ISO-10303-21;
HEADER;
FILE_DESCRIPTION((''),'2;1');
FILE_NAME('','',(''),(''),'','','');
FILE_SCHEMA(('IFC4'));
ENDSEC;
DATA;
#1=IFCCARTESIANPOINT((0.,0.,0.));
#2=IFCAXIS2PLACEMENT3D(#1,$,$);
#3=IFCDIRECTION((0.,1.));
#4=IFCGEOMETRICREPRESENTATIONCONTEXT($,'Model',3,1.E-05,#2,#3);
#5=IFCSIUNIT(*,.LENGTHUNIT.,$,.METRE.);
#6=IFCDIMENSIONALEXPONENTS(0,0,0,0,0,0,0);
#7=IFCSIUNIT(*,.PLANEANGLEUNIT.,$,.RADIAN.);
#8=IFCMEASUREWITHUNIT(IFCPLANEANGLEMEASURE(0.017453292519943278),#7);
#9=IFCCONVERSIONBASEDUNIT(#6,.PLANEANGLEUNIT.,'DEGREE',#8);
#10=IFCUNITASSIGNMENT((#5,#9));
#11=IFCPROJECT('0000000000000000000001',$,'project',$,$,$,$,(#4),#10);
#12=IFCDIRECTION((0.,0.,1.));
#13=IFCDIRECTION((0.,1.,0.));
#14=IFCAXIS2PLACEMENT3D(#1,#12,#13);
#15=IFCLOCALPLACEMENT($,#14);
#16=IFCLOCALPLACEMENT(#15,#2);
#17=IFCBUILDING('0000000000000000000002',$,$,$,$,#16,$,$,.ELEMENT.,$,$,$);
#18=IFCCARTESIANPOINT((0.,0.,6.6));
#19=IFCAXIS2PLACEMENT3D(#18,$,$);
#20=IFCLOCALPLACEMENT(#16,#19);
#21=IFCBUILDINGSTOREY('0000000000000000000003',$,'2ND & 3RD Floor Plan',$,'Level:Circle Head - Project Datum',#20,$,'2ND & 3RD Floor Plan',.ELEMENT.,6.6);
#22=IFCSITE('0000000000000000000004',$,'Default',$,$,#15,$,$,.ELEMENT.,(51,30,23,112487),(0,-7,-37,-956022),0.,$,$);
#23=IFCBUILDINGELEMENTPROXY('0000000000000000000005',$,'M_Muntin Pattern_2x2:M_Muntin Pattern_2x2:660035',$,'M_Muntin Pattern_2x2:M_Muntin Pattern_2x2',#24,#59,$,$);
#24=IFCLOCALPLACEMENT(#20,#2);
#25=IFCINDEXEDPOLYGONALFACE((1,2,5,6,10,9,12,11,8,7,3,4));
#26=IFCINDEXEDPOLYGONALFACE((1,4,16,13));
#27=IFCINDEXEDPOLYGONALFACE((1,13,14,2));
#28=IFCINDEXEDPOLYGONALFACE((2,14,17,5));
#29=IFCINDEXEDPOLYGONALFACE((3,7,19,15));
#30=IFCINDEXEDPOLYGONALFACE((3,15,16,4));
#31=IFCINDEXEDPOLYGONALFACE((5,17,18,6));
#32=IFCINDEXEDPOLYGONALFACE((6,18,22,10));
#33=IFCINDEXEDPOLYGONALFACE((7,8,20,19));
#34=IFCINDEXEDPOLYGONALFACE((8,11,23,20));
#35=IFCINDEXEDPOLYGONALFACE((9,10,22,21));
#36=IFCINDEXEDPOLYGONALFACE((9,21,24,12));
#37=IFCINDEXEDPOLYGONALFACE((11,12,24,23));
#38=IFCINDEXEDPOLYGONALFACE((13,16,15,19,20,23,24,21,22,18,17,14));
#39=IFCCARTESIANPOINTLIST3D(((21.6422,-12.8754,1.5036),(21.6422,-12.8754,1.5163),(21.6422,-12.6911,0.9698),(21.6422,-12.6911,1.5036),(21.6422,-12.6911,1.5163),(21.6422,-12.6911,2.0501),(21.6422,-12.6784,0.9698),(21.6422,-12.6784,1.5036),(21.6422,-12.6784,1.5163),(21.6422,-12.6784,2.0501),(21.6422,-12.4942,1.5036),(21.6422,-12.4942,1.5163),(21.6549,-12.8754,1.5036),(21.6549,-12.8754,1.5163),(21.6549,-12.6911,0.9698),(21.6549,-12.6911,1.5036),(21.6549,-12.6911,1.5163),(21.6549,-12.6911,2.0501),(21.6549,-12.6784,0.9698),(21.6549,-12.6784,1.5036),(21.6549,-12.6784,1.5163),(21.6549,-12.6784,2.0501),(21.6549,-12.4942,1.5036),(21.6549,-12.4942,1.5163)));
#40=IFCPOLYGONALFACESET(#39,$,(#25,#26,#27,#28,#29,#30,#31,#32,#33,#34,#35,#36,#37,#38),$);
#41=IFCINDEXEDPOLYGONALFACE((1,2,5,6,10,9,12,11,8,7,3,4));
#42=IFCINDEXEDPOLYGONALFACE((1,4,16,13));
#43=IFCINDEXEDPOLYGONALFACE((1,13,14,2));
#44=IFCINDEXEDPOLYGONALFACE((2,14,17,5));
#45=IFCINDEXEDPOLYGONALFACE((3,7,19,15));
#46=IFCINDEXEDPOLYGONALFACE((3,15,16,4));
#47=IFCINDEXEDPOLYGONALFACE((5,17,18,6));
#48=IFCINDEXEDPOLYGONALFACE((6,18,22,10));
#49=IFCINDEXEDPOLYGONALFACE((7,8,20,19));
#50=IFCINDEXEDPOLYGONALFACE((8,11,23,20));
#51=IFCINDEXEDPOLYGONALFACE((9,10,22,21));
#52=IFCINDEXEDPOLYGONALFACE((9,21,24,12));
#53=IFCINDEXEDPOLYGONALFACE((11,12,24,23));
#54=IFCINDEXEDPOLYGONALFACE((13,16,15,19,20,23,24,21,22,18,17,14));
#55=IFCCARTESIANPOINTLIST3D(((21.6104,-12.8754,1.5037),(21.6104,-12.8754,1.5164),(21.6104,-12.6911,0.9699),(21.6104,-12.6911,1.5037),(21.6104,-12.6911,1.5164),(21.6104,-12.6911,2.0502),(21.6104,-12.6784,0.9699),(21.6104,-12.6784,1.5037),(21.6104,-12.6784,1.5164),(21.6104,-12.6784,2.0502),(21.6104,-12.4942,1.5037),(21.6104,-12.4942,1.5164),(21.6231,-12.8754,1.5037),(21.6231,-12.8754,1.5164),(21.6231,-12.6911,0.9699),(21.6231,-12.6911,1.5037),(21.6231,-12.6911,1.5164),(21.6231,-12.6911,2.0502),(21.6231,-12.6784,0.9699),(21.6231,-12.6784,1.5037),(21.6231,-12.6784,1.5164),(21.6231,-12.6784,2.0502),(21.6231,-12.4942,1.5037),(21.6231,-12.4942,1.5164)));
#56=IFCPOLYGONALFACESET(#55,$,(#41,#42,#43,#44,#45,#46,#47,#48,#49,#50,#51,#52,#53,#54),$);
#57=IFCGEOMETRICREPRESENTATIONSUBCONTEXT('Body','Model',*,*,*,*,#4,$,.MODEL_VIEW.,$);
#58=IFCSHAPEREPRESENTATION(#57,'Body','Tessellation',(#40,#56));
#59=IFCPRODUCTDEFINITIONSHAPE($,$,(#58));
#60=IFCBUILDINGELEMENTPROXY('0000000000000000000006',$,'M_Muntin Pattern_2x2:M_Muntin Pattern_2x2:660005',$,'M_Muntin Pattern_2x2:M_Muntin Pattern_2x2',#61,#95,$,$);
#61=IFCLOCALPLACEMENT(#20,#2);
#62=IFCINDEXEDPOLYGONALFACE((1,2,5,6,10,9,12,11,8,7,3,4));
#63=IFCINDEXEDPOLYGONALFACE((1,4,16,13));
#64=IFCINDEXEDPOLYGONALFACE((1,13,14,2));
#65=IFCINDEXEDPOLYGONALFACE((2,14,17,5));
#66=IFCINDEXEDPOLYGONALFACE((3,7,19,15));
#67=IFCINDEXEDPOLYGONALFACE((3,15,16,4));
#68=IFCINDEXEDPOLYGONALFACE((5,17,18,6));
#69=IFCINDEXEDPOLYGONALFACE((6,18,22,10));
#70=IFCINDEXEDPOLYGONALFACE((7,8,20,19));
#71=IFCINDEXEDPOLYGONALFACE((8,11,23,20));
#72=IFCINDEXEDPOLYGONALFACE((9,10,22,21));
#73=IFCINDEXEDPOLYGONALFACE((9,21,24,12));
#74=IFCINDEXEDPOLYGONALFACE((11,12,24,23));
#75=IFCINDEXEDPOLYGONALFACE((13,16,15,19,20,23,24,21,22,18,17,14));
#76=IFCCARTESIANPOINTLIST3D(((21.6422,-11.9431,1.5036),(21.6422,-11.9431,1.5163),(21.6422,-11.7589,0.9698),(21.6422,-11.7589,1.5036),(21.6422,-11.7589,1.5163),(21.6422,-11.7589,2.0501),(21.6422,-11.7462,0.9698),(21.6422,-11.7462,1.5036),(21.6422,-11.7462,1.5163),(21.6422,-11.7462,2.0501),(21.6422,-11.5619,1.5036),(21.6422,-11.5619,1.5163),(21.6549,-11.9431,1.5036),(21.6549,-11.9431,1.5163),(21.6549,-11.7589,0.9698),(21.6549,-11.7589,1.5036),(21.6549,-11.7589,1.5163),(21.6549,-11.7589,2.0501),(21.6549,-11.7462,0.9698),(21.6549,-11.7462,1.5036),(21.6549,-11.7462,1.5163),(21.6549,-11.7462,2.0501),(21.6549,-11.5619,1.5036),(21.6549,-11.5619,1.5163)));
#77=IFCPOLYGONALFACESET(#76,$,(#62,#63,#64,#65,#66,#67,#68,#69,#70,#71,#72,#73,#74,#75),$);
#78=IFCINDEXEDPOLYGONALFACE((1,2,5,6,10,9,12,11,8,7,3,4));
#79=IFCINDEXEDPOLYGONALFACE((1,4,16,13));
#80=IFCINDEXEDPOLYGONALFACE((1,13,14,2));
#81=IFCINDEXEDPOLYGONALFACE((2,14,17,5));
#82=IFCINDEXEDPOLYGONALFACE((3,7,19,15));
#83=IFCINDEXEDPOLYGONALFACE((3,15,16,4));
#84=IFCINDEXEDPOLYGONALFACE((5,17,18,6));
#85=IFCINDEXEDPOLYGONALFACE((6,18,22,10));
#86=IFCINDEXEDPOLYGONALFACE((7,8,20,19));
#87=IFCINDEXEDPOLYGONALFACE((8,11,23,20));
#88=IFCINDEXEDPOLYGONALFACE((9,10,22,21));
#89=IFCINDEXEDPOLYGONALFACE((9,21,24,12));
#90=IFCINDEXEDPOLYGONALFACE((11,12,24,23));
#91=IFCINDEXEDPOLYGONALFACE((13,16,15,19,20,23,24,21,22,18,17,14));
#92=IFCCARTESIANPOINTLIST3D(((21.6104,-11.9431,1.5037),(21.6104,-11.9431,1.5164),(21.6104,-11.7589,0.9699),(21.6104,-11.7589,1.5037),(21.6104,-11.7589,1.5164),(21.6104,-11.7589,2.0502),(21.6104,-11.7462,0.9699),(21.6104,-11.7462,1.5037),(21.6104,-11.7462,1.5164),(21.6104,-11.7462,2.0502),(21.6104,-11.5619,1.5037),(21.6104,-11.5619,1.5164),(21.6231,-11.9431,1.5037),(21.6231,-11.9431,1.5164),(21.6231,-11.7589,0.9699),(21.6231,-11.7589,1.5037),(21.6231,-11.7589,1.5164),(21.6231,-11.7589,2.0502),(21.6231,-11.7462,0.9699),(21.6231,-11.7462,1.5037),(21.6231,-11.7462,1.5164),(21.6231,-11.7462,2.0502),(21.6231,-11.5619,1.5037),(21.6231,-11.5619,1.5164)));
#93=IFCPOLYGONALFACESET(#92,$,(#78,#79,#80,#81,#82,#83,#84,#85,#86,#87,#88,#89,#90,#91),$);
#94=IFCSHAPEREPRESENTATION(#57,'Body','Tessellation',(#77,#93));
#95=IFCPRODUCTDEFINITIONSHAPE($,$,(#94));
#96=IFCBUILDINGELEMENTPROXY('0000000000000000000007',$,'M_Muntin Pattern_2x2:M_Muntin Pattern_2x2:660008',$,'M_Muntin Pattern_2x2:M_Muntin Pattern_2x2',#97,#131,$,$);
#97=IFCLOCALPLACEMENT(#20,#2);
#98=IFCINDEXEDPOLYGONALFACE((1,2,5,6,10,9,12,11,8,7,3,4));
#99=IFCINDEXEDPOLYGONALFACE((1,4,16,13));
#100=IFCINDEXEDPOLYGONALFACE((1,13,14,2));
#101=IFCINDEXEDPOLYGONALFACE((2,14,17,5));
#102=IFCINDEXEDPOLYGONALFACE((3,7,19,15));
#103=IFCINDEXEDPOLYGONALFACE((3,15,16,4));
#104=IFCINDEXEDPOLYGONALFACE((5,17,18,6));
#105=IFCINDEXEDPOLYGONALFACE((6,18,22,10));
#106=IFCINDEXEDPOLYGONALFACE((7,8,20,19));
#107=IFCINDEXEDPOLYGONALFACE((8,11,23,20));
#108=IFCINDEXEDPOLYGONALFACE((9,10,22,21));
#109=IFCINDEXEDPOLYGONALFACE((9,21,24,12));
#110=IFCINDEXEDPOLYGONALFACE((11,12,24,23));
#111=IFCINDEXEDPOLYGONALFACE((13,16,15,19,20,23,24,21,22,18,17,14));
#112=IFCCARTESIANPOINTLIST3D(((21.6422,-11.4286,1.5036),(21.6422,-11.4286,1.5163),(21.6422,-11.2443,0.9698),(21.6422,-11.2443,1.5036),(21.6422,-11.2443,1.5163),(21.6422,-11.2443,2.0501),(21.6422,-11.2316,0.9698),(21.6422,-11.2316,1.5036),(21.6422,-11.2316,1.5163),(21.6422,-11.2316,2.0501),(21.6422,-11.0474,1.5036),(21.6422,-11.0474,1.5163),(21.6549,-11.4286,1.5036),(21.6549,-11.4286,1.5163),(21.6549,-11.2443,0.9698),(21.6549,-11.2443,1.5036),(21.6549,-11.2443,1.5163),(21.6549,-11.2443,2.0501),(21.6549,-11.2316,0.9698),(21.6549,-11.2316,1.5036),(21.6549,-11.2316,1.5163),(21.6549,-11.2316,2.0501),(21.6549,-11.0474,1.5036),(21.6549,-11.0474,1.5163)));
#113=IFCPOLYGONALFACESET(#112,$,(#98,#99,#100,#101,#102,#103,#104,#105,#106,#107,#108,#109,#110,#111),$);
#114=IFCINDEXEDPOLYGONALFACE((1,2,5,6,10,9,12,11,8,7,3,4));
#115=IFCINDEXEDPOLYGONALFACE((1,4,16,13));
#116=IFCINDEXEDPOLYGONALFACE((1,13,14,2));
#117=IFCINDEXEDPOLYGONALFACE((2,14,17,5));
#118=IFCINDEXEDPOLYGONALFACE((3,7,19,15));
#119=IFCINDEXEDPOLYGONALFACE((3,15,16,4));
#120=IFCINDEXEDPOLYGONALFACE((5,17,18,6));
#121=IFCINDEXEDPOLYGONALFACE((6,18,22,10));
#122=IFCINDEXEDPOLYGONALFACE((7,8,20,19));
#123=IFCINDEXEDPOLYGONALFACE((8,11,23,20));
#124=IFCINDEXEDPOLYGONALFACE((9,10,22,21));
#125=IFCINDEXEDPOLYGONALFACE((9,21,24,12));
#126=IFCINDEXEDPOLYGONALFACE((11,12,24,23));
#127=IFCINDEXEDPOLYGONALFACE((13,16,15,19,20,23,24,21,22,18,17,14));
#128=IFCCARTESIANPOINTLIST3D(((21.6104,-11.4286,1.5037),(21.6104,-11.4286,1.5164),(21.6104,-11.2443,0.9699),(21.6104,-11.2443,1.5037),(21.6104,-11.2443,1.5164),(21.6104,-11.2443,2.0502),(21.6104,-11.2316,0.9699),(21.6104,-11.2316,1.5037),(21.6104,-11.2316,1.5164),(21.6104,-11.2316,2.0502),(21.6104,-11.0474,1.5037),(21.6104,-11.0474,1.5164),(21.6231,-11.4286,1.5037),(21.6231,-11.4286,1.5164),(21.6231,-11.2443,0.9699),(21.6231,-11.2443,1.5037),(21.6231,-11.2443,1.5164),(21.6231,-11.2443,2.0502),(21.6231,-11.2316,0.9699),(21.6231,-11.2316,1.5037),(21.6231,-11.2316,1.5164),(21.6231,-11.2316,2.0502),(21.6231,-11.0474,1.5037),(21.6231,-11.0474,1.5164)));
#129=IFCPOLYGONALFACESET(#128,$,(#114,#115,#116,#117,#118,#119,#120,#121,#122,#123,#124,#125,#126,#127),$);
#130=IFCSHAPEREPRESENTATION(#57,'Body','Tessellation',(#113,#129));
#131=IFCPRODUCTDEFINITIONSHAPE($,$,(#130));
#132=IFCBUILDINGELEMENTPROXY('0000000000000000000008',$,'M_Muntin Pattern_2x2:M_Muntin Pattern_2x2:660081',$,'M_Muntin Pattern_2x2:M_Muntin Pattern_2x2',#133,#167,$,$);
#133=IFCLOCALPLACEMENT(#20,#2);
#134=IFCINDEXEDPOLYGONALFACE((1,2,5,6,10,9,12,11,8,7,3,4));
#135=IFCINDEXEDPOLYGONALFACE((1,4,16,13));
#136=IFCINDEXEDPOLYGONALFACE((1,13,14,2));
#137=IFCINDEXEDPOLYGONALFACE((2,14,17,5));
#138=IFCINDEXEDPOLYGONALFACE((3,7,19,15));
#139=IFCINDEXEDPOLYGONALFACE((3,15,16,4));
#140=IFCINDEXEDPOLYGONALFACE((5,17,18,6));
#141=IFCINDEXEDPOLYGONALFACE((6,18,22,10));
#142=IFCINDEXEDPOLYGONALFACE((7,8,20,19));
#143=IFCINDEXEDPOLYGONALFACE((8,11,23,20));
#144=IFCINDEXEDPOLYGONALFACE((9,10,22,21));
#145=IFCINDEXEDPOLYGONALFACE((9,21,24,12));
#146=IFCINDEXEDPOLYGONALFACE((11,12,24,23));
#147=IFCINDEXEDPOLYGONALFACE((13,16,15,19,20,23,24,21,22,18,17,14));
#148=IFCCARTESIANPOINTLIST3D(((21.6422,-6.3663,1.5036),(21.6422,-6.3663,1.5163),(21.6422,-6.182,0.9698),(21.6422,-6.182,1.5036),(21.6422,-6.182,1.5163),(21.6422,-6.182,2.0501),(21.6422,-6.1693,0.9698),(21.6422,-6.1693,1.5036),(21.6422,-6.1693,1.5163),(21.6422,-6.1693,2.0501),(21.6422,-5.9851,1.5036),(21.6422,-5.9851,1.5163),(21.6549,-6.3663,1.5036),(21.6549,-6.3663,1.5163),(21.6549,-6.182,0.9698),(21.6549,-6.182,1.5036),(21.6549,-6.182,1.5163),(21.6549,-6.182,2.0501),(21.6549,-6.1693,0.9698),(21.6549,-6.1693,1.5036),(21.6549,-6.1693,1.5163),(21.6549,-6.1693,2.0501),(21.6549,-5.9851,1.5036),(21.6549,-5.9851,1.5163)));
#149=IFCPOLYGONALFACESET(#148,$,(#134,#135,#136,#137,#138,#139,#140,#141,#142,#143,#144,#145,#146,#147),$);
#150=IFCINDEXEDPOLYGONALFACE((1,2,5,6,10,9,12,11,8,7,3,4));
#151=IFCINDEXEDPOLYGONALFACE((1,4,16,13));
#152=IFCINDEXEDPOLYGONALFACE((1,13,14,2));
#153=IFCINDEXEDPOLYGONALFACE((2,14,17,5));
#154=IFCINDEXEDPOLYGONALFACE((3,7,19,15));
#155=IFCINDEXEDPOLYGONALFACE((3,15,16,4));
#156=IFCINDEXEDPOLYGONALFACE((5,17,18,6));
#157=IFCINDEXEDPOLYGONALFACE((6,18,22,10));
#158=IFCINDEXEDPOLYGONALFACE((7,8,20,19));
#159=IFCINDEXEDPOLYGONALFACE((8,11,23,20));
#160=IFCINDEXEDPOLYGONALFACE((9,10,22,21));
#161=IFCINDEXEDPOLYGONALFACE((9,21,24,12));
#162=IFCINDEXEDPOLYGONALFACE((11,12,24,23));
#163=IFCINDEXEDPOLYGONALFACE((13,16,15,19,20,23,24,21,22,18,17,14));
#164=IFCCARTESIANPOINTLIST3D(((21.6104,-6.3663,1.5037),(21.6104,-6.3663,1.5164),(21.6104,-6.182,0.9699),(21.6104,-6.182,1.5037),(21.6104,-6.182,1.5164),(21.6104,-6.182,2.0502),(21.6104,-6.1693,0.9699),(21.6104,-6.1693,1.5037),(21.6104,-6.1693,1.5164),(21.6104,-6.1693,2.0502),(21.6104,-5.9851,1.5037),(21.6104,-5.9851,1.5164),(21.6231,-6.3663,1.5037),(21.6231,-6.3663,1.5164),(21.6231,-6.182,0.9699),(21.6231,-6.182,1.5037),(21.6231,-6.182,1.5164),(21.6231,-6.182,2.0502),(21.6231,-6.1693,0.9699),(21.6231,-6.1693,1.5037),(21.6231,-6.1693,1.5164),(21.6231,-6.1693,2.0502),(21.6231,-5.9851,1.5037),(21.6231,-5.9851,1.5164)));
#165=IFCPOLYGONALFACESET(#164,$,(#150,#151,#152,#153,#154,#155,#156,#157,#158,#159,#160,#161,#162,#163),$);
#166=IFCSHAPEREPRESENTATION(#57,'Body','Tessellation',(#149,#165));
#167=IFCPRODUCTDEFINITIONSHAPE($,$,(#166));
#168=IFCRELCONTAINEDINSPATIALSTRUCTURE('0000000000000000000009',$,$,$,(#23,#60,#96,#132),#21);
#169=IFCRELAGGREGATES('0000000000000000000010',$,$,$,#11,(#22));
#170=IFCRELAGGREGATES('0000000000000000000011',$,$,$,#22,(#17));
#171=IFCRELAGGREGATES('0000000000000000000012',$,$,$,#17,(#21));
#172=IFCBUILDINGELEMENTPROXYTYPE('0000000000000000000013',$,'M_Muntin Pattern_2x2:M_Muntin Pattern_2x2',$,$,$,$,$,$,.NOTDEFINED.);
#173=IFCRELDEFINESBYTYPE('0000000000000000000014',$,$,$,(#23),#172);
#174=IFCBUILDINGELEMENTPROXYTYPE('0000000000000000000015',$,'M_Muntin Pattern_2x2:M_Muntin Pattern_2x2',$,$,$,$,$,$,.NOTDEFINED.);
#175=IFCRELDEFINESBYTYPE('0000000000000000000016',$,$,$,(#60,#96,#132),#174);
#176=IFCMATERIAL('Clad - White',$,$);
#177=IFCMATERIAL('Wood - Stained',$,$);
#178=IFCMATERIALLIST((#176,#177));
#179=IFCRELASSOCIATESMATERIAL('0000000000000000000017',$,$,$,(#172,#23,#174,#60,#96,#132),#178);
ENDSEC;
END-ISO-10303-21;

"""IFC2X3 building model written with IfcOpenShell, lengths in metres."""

from ifc_helpers import new_model, entity, si_unit, converted_unit, direction, frame, origin, place, context, subcontext, project, spatial, polyline, outline, extrude, source, transform, mapped, material, material_list, type_object, type_shapes, element, save


model = new_model("IFC2X3")

# Units and contexts
model_context = context("Model", 3, precision=1e-05, world=origin(), true_north=direction((0.0, 1.0)))
body_context = subcontext(model_context, "Body", "Model", "MODEL_VIEW")
ifc_project = project(units=[si_unit("LENGTHUNIT", "METRE"), converted_unit("PLANEANGLEUNIT", "DEGREE", entity("IfcPlaneAngleMeasure", 0.017453292519943278), si_unit("PLANEANGLEUNIT", "RADIAN"), dimensions=[0, 0, 0, 0, 0, 0, 0])], contexts=[model_context])

# Site, building, storey
site_placement = place(None, frame((0.0, 0.0, 0.0), z_axis=(0.0, 0.0, 1.0), x_axis=(0.0, 1.0, 0.0)))
site = spatial("IfcSite", under=ifc_project, at=site_placement, Name="Default", CompositionType="ELEMENT", RefLatitude=(51, 30, 23, 112487), RefLongitude=(0, -7, -37, -956022), RefElevation=0.0)
building_placement = place(site_placement, origin())
building = spatial("IfcBuilding", under=site, at=building_placement, CompositionType="ELEMENT")
storey_placement = place(building_placement, frame((0.0, 0.0, 6.6)))
storey = spatial("IfcBuildingStorey", under=building, at=storey_placement, Name="2ND & 3RD Floor Plan", ObjectType="Level:Circle Head - Project Datum", LongName="2ND & 3RD Floor Plan", CompositionType="ELEMENT", Elevation=6.6)

# Building element proxies
ifc_material_1 = material(Name="Clad - White")
ifc_material_2 = material(Name="Wood - Stained")
ifc_material_list = material_list([ifc_material_1, ifc_material_2])
building_element_proxy_type_1 = type_object("IfcBuildingElementProxyType", Name="M_Muntin Pattern_2x2:M_Muntin Pattern_2x2", PredefinedType="NOTDEFINED", material=ifc_material_list)
shared_shape_1 = source(origin(), body_context, "Body", "SweptSolid", [
    extrude(outline(polyline([(0.0064, -0.0064), (0.5401, -0.0064), (0.5401, 0.0063), (0.0064, 0.0063), (0.0064, 0.1906), (-0.0063, 0.1906), (-0.0063, 0.0063), (-0.5402, 0.0063), (-0.5402, -0.0064), (-0.0063, -0.0064), (-0.0063, -0.1906), (0.0064, -0.1906), (0.0064, -0.0064)])), frame((0.0, 0.0095, 0.5401), z_axis=(0.0, 1.0, 0.0), x_axis=(0.0, 0.0, 1.0)), (0.0, 0.0, 1.0), 0.0127),
    extrude(outline(polyline([(0.0064, -0.0064), (0.5402, -0.0064), (0.5402, 0.0063), (0.0064, 0.0063), (0.0064, 0.1906), (-0.0063, 0.1906), (-0.0063, 0.0063), (-0.5402, 0.0063), (-0.5402, -0.0064), (-0.0063, -0.0064), (-0.0063, -0.1906), (0.0064, -0.1906), (0.0064, -0.0064)])), frame((0.0, -0.0222, 0.5402), z_axis=(0.0, 1.0, 0.0), x_axis=(0.0, 0.0, 1.0)), (0.0, 0.0, 1.0), 0.0127),
])
type_shapes(building_element_proxy_type_1, [shared_shape_1])
for number, where, z_axis, x_axis, name in (
    (1, (21.6326, -12.6848, 0.9699), (0.0, 0.0, 1.0), (0.0, -1.0, 0.0), "M_Muntin Pattern_2x2:M_Muntin Pattern_2x2:660035"),
):
    element("IfcBuildingElementProxy", number, at=place(storey_placement, frame(where, z_axis=z_axis, x_axis=x_axis)), inside=storey, type_object=building_element_proxy_type_1, material=ifc_material_list, Name=name, ObjectType="M_Muntin Pattern_2x2:M_Muntin Pattern_2x2", context=body_context, shape_type="MappedRepresentation", body=[
        mapped(shared_shape_1, transform((0.0, 0.0, 0.0), scale=1.0)),
    ])
building_element_proxy_type_2 = type_object("IfcBuildingElementProxyType", Name="M_Muntin Pattern_2x2:M_Muntin Pattern_2x2", PredefinedType="NOTDEFINED", material=ifc_material_list)
shared_shape_2 = source(origin(), body_context, "Body", "SweptSolid", [
    extrude(outline(polyline([(0.0064, -0.0064), (0.5401, -0.0064), (0.5401, 0.0063), (0.0064, 0.0063), (0.0064, 0.1906), (-0.0063, 0.1906), (-0.0063, 0.0063), (-0.5402, 0.0063), (-0.5402, -0.0064), (-0.0063, -0.0064), (-0.0063, -0.1906), (0.0064, -0.1906), (0.0064, -0.0064)])), frame((0.0, -0.0222, 0.5401), z_axis=(0.0, 1.0, 0.0), x_axis=(0.0, 0.0, 1.0)), (0.0, 0.0, 1.0), 0.0127),
    extrude(outline(polyline([(0.0064, -0.0064), (0.5402, -0.0064), (0.5402, 0.0063), (0.0064, 0.0063), (0.0064, 0.1906), (-0.0063, 0.1906), (-0.0063, 0.0063), (-0.5402, 0.0063), (-0.5402, -0.0064), (-0.0063, -0.0064), (-0.0063, -0.1906), (0.0064, -0.1906), (0.0064, -0.0064)])), frame((0.0, 0.0095, 0.5402), z_axis=(0.0, 1.0, 0.0), x_axis=(0.0, 0.0, 1.0)), (0.0, 0.0, 1.0), 0.0127),
])
type_shapes(building_element_proxy_type_2, [shared_shape_2])
for number, where, z_axis, x_axis, name in (
    (2, (21.6326, -11.7525, 0.9699), (0.0, 0.0, 1.0), (0.0, 1.0, 0.0), "M_Muntin Pattern_2x2:M_Muntin Pattern_2x2:660005"),
    (3, (21.6326, -11.238, 0.9699), (0.0, 0.0, 1.0), (0.0, 1.0, 0.0), "M_Muntin Pattern_2x2:M_Muntin Pattern_2x2:660008"),
    (4, (21.6326, -6.1757, 0.9699), (0.0, 0.0, 1.0), (0.0, 1.0, 0.0), "M_Muntin Pattern_2x2:M_Muntin Pattern_2x2:660081"),
):
    element("IfcBuildingElementProxy", number, at=place(storey_placement, frame(where, z_axis=z_axis, x_axis=x_axis)), inside=storey, type_object=building_element_proxy_type_2, material=ifc_material_list, Name=name, ObjectType="M_Muntin Pattern_2x2:M_Muntin Pattern_2x2", context=body_context, shape_type="MappedRepresentation", body=[
        mapped(shared_shape_2, transform((0.0, 0.0, 0.0), scale=1.0)),
    ])

save(model, "model.ifc")
